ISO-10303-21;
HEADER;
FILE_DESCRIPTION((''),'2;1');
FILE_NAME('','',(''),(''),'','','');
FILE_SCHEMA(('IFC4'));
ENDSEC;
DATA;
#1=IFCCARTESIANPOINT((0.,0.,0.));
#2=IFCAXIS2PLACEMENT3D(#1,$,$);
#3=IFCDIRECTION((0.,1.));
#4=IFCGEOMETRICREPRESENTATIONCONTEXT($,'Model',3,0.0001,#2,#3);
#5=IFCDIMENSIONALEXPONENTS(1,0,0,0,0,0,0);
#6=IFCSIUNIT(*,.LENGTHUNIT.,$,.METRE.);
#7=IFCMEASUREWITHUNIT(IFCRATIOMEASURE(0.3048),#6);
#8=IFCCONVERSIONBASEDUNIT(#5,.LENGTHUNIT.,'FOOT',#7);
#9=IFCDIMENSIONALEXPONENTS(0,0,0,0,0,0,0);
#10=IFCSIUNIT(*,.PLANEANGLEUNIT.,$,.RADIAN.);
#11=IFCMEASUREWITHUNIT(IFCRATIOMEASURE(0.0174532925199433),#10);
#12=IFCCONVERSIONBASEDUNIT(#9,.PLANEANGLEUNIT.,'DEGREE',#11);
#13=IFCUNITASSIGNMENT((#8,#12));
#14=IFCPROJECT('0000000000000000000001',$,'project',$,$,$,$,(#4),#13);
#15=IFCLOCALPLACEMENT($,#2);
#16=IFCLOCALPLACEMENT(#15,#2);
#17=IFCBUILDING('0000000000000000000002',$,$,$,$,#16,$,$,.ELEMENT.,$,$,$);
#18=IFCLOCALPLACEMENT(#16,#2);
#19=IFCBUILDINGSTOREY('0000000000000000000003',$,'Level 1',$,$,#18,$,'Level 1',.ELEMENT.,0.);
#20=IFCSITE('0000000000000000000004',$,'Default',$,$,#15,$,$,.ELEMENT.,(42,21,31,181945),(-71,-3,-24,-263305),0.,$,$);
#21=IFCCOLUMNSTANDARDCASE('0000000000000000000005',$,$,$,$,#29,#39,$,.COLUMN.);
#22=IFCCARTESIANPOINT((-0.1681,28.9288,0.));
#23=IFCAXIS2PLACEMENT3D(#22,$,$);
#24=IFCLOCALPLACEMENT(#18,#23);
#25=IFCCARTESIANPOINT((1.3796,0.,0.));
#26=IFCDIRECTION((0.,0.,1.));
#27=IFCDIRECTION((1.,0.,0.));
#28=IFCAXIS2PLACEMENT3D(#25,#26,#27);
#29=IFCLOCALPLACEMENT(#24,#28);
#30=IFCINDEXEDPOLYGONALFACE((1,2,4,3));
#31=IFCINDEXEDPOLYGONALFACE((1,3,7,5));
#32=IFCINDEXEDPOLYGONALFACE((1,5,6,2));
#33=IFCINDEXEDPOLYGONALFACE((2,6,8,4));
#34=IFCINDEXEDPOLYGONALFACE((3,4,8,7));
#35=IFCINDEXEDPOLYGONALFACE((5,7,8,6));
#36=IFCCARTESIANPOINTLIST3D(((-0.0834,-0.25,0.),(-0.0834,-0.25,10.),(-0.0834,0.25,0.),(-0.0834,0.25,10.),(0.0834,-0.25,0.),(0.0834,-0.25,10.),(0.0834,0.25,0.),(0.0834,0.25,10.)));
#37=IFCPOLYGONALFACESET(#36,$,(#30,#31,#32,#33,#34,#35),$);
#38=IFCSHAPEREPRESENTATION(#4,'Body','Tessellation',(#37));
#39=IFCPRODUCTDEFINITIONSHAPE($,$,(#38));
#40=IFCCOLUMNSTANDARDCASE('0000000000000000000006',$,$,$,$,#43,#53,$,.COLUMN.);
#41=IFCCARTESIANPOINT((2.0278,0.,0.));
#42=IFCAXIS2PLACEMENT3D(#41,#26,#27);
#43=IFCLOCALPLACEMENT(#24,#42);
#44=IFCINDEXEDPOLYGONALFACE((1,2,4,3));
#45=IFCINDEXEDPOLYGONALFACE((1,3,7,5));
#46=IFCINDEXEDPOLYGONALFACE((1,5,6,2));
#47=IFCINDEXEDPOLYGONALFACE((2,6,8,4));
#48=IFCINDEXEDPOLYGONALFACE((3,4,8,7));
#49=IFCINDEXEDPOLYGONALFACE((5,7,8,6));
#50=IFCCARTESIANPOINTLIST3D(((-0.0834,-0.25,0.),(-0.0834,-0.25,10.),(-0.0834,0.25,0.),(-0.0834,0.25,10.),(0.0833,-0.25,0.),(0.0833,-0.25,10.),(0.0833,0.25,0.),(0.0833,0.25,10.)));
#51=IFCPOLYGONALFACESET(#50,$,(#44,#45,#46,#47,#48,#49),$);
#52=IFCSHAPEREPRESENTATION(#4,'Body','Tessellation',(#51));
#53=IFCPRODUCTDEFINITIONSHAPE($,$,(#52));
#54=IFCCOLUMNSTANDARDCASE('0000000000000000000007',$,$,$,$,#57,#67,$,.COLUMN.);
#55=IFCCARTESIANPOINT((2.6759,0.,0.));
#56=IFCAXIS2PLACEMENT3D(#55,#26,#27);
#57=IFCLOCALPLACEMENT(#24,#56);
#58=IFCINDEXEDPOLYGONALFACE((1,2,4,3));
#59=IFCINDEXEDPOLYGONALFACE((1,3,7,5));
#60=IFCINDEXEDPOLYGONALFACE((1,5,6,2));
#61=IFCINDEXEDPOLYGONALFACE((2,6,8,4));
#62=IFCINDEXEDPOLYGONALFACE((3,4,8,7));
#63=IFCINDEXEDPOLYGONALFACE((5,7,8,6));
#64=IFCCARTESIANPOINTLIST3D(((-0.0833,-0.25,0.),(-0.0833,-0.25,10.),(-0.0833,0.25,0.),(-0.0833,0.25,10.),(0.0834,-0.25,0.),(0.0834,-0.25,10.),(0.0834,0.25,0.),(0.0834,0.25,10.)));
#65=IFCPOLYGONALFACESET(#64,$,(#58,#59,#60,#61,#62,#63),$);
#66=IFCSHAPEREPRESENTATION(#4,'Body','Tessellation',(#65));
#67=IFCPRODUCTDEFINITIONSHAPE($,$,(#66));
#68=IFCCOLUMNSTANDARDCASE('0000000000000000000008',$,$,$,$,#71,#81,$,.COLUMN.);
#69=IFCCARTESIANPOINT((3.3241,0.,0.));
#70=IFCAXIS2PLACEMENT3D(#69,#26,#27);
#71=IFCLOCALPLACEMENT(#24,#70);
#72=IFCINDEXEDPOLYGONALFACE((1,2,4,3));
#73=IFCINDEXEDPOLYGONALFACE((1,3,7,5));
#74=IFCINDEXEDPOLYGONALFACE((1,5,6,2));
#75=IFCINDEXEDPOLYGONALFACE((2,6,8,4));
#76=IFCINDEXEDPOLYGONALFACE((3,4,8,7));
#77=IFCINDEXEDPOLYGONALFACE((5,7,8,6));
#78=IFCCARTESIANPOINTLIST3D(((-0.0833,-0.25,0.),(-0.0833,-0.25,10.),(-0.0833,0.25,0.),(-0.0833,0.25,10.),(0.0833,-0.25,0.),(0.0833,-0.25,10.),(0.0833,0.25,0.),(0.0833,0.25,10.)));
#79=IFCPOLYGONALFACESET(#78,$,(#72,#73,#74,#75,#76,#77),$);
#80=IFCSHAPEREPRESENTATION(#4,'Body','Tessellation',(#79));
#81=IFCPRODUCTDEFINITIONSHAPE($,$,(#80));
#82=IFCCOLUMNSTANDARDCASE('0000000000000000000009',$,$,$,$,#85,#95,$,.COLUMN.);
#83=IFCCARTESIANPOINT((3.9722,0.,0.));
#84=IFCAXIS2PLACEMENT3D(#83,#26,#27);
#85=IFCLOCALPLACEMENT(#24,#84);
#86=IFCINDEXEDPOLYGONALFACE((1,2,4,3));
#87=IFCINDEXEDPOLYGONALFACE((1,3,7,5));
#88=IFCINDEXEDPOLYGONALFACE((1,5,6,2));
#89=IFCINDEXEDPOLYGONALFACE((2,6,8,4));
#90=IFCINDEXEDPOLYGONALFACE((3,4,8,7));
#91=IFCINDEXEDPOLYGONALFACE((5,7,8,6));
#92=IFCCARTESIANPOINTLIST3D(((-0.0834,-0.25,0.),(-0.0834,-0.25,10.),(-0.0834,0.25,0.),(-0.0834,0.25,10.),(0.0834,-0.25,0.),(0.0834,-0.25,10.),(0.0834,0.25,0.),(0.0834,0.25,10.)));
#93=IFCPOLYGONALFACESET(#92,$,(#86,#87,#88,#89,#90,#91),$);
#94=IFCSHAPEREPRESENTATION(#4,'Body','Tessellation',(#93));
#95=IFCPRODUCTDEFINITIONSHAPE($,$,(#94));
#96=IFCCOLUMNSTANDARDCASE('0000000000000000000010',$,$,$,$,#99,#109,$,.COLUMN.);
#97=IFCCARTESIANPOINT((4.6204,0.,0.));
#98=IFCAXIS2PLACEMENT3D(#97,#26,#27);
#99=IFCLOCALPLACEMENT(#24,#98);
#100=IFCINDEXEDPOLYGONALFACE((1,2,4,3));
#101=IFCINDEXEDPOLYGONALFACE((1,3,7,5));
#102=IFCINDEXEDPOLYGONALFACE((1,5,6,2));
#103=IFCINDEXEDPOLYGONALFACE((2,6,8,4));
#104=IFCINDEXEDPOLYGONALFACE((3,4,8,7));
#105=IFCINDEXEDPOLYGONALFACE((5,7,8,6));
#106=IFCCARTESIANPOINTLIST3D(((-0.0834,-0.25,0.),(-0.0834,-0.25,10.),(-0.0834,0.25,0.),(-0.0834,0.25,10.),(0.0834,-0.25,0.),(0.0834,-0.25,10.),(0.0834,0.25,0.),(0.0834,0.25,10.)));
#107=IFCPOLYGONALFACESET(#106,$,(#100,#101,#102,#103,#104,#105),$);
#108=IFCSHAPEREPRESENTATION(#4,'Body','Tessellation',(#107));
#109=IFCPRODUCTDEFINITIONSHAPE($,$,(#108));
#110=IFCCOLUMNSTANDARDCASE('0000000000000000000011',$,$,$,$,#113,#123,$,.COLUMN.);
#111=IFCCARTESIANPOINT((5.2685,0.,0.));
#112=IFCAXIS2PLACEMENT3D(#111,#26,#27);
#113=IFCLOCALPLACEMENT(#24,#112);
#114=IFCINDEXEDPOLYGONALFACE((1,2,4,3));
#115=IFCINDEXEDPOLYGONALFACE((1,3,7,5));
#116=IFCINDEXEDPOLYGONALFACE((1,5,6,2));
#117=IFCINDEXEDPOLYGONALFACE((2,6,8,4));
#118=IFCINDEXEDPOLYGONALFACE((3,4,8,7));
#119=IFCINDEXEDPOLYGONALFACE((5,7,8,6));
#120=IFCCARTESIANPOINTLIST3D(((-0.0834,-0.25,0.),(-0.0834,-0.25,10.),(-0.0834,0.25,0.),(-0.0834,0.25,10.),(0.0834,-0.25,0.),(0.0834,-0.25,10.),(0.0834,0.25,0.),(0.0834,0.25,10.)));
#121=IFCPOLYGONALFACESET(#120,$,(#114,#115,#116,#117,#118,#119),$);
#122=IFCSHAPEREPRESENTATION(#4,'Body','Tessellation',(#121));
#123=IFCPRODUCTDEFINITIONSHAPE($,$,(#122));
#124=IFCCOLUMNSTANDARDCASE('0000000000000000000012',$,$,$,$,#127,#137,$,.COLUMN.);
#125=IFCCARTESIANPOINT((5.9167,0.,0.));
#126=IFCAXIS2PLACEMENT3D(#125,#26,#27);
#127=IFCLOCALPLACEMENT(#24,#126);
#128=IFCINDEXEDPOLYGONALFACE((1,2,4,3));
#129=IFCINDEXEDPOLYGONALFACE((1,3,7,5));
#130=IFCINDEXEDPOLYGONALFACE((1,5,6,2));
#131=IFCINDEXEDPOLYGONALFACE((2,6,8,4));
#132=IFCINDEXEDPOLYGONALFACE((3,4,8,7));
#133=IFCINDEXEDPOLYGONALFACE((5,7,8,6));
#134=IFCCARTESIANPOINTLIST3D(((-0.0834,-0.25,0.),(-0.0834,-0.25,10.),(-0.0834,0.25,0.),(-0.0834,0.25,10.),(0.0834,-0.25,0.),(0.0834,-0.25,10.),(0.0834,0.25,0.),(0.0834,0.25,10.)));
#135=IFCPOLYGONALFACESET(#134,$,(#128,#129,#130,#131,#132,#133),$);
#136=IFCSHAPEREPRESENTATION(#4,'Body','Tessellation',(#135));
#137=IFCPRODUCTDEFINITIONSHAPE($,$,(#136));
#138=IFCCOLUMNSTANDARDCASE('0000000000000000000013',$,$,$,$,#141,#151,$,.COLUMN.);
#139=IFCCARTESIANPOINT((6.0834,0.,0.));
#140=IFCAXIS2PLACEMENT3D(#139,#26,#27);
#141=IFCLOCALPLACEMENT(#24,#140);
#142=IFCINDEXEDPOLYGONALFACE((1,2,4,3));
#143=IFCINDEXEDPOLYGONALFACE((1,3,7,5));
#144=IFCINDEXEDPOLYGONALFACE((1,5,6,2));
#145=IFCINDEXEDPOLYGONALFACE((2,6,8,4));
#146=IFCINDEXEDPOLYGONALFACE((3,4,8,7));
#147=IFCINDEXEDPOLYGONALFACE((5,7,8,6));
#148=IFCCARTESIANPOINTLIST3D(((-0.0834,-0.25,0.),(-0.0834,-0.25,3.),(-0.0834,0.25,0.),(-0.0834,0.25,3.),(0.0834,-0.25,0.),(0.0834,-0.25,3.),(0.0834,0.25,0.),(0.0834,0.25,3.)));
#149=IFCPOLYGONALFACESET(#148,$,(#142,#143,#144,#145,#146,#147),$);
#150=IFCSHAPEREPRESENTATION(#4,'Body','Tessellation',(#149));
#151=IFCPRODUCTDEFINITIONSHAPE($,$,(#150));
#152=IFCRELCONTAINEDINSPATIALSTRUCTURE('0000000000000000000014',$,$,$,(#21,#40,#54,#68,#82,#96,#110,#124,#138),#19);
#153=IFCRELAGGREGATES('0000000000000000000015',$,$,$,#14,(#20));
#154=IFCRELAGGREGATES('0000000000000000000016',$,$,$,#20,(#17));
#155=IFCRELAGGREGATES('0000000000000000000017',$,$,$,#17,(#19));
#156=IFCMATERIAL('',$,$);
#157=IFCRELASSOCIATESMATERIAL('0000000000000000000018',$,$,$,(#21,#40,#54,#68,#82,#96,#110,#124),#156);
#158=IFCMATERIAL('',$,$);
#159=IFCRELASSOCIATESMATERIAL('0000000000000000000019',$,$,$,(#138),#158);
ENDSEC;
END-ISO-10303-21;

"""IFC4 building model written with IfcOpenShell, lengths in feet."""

from ifc_helpers import new_model, entity, si_unit, converted_unit, direction, frame, origin, place, context, project, spatial, rectangle, extrude, material, element, save


model = new_model("IFC4")

# Units and contexts
model_context = context("Model", 3, precision=0.0001, world=origin(), true_north=direction((0.0, 1.0)))
ifc_project = project(units=[converted_unit("LENGTHUNIT", "FOOT", entity("IfcRatioMeasure", 0.3048), si_unit("LENGTHUNIT", "METRE"), dimensions=[1, 0, 0, 0, 0, 0, 0]), converted_unit("PLANEANGLEUNIT", "DEGREE", entity("IfcRatioMeasure", 0.0174532925199433), si_unit("PLANEANGLEUNIT", "RADIAN"), dimensions=[0, 0, 0, 0, 0, 0, 0])], contexts=[model_context])

# Site, building, storey
site_placement = place(None, origin())
site = spatial("IfcSite", under=ifc_project, at=site_placement, Name="Default", CompositionType="ELEMENT", RefLatitude=(42, 21, 31, 181945), RefLongitude=(-71, -3, -24, -263305), RefElevation=0.0)
building_placement = place(site_placement, origin())
building = spatial("IfcBuilding", under=site, at=building_placement, CompositionType="ELEMENT")
storey_placement = place(building_placement, origin())
storey = spatial("IfcBuildingStorey", under=building, at=storey_placement, Name="Level 1", LongName="Level 1", CompositionType="ELEMENT", Elevation=0.0)

# Columns
ifc_material_1 = material(Name="")
placement = place(storey_placement, frame((-0.1681, 28.9288, 0.0)))
for number, where, z_axis, x_axis in (
    (1, (1.3796, 0.0, 0.0), (0.0, 0.0, 1.0), (1.0, 0.0, 0.0)),
    (2, (2.0278, 0.0, 0.0), (0.0, 0.0, 1.0), (1.0, 0.0, 0.0)),
    (3, (2.6759, 0.0, 0.0), (0.0, 0.0, 1.0), (1.0, 0.0, 0.0)),
    (4, (3.3241, 0.0, 0.0), (0.0, 0.0, 1.0), (1.0, 0.0, 0.0)),
    (5, (3.9722, 0.0, 0.0), (0.0, 0.0, 1.0), (1.0, 0.0, 0.0)),
    (6, (4.6204, 0.0, 0.0), (0.0, 0.0, 1.0), (1.0, 0.0, 0.0)),
    (7, (5.2685, 0.0, 0.0), (0.0, 0.0, 1.0), (1.0, 0.0, 0.0)),
    (8, (5.9167, 0.0, 0.0), (0.0, 0.0, 1.0), (1.0, 0.0, 0.0)),
):
    element("IfcColumnStandardCase", number, at=place(placement, frame(where, z_axis=z_axis, x_axis=x_axis)), inside=storey, material=ifc_material_1, PredefinedType="COLUMN", context=model_context, shape_type="SweptSolid", body=[
        extrude(rectangle(XDim=0.1667, YDim=0.5), origin(), (0.0, 0.0, 1.0), 10.0),
    ])
ifc_material_2 = material(Name="")
for number, where, z_axis, x_axis in (
    (9, (6.0834, 0.0, 0.0), (0.0, 0.0, 1.0), (1.0, 0.0, 0.0)),
):
    element("IfcColumnStandardCase", number, at=place(placement, frame(where, z_axis=z_axis, x_axis=x_axis)), inside=storey, material=ifc_material_2, PredefinedType="COLUMN", context=model_context, shape_type="SweptSolid", body=[
        extrude(rectangle(XDim=0.1667, YDim=0.5), origin(), (0.0, 0.0, 1.0), 3.0),
    ])

save(model, "model.ifc")
